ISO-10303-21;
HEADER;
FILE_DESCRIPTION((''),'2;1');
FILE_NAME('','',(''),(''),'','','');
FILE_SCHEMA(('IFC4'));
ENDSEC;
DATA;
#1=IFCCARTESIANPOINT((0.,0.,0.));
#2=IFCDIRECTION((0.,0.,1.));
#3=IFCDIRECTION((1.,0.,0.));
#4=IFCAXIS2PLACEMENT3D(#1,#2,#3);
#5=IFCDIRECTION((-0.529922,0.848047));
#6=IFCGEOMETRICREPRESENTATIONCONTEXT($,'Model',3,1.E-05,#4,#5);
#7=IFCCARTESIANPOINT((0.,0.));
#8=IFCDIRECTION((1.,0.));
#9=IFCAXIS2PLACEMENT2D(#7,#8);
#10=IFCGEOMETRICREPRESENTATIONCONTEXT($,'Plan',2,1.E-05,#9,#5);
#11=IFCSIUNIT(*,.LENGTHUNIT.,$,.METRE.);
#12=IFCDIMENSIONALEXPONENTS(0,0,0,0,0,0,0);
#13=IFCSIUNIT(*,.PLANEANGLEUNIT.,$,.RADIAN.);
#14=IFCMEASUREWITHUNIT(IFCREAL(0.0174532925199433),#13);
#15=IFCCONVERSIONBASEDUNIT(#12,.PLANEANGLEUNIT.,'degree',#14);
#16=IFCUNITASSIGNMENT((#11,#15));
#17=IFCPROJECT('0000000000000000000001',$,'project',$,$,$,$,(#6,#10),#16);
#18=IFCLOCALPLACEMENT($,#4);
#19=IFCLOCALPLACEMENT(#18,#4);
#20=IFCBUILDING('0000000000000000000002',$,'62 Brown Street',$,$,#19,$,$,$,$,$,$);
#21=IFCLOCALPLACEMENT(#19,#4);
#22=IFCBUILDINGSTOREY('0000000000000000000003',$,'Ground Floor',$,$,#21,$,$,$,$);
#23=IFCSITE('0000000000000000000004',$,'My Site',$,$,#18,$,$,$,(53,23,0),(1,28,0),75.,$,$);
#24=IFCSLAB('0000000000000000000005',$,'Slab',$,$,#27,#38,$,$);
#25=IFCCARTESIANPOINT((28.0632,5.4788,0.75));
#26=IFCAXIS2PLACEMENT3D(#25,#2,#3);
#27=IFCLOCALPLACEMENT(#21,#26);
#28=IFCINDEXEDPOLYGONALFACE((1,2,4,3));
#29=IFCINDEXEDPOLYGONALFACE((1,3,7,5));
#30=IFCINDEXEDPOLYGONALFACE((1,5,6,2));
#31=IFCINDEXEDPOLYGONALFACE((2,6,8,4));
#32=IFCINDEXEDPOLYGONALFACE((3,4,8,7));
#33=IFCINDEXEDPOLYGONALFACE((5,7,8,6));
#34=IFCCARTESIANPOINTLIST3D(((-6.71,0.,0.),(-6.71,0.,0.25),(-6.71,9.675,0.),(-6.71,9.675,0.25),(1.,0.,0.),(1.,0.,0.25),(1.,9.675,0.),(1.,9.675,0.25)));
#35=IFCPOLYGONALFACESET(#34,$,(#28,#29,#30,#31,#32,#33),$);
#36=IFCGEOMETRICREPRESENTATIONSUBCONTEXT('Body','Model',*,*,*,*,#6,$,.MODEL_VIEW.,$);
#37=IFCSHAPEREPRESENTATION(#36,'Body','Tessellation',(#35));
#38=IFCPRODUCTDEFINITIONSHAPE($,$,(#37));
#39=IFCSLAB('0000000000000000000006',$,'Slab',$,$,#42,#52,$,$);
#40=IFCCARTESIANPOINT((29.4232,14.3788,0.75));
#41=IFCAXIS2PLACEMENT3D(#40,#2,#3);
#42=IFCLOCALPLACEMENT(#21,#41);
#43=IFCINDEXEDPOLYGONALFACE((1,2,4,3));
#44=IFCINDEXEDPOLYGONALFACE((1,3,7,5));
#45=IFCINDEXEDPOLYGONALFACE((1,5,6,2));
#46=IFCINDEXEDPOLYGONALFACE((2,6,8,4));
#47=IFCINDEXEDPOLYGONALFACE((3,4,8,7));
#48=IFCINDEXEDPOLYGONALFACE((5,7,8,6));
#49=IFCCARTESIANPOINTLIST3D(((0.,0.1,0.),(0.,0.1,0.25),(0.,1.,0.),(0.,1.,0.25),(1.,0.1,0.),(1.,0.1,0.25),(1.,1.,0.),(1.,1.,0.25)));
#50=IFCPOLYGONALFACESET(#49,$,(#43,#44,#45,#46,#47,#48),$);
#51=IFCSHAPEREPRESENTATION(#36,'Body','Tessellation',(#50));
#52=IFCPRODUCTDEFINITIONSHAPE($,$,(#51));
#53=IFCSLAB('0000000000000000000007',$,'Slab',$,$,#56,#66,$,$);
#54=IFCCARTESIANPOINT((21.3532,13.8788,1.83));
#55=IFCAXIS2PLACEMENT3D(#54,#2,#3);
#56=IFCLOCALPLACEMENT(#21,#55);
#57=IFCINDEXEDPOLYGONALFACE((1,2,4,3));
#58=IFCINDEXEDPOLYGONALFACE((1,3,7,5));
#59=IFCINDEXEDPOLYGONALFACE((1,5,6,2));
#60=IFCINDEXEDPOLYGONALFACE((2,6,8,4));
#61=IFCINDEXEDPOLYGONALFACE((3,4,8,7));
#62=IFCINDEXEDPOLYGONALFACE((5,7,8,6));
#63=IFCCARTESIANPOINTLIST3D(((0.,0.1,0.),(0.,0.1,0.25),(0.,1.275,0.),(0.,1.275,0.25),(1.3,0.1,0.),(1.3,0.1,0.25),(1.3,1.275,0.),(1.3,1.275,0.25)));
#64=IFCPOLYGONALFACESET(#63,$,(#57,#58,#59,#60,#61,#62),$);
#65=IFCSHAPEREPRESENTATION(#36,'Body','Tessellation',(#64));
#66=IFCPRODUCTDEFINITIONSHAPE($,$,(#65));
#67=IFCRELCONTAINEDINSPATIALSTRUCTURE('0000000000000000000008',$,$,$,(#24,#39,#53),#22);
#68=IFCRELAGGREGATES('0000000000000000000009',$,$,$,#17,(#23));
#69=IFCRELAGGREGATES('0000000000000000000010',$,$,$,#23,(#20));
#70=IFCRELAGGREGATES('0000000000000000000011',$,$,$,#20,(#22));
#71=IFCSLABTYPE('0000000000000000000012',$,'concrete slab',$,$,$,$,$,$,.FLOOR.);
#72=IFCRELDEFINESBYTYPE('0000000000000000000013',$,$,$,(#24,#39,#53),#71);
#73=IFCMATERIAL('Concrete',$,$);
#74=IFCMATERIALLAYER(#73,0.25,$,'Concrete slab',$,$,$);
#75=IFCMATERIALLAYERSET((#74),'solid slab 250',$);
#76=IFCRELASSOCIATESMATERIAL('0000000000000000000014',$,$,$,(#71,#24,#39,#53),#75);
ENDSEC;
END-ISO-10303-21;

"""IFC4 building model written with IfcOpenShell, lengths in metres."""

from ifc_helpers import new_model, entity, si_unit, converted_unit, direction, frame, origin_with_axes, origin_2d_with_axis, place, context, subcontext, project, spatial, line, indexed_curve, outline, extrude, material, layer, layer_set, layer_usage, type_object, element, save


model = new_model("IFC4")

# Units and contexts
model_context = context("Model", 3, precision=1e-05, world=origin_with_axes(), true_north=direction((-0.529922, 0.848047)))
plan_context = context("Plan", 2, precision=1e-05, world=origin_2d_with_axis(), true_north=direction((-0.529922, 0.848047)))
body_context_1 = subcontext(model_context, "Body", "Model", "MODEL_VIEW")
ifc_project = project(units=[si_unit("LENGTHUNIT", "METRE"), converted_unit("PLANEANGLEUNIT", "degree", entity("IfcReal", 0.0174532925199433), si_unit("PLANEANGLEUNIT", "RADIAN"), dimensions=[0, 0, 0, 0, 0, 0, 0])], contexts=[model_context, plan_context])

# Site, building, storey
site_placement = place(None, origin_with_axes())
site = spatial("IfcSite", under=ifc_project, at=site_placement, Name="My Site", RefLatitude=(53, 23, 0), RefLongitude=(1, 28, 0), RefElevation=75.0)
building_placement = place(site_placement, origin_with_axes())
building = spatial("IfcBuilding", under=site, at=building_placement, Name="62 Brown Street")
storey_placement = place(building_placement, origin_with_axes())
storey = spatial("IfcBuildingStorey", under=building, at=storey_placement, Name="Ground Floor")

# Shared definitions
ifc_material_1 = material(Name="Concrete")

# Slabs
ifc_layer_1 = layer(ifc_material_1, 0.25, Name="Concrete slab")
ifc_layer_set_1 = layer_set([ifc_layer_1], Name="solid slab 250")
slab_type = type_object("IfcSlabType", Name="concrete slab", PredefinedType="FLOOR", material=ifc_layer_set_1)
ifc_layer_usage_1 = layer_usage(ifc_layer_set_1, "AXIS3", "POSITIVE", 0.0)
slab_1_placement = place(storey_placement, frame((28.0632, 5.4788, 0.75), z_axis=(0.0, 0.0, 1.0), x_axis=(1.0, 0.0, 0.0)))
element("IfcSlab", 1, at=slab_1_placement, inside=storey, type_object=slab_type, material=ifc_layer_usage_1, Name="Slab", context=body_context_1, shape_type="SweptSolid", body=[
    extrude(outline(indexed_curve([(-6.71, 0.0), (-6.71, 9.675), (1.0, 9.675), (1.0, 0.0), (-6.71, 0.0)])), None, (0.0, 0.0, 1.0), 0.25),
])
ifc_layer_usage_2 = layer_usage(ifc_layer_set_1, "AXIS3", "POSITIVE", 0.0)
slab_2_placement = place(storey_placement, frame((29.4232, 14.3788, 0.75), z_axis=(0.0, 0.0, 1.0), x_axis=(1.0, 0.0, 0.0)))
element("IfcSlab", 2, at=slab_2_placement, inside=storey, type_object=slab_type, material=ifc_layer_usage_2, Name="Slab", context=body_context_1, shape_type="SweptSolid", body=[
    extrude(outline(indexed_curve([(1.0, 1.0), (1.0, 0.1), (0.0, 0.1), (0.0, 1.0)], segments=[line(3, 2), line(2, 1), line(1, 4), line(4, 3)], self_intersect=False)), None, (0.0, 0.0, 1.0), 0.25),
])
ifc_layer_usage_3 = layer_usage(ifc_layer_set_1, "AXIS3", "POSITIVE", 0.0)
slab_3_placement = place(storey_placement, frame((21.3532, 13.8788, 1.83), z_axis=(0.0, 0.0, 1.0), x_axis=(1.0, 0.0, 0.0)))
element("IfcSlab", 3, at=slab_3_placement, inside=storey, type_object=slab_type, material=ifc_layer_usage_3, Name="Slab", context=body_context_1, shape_type="SweptSolid", body=[
    extrude(outline(indexed_curve([(0.0, 0.1), (1.3, 0.1), (1.3, 1.275), (0.0, 1.275), (0.0, 0.1)])), None, (0.0, 0.0, 1.0), 0.25),
])

save(model, "model.ifc")
